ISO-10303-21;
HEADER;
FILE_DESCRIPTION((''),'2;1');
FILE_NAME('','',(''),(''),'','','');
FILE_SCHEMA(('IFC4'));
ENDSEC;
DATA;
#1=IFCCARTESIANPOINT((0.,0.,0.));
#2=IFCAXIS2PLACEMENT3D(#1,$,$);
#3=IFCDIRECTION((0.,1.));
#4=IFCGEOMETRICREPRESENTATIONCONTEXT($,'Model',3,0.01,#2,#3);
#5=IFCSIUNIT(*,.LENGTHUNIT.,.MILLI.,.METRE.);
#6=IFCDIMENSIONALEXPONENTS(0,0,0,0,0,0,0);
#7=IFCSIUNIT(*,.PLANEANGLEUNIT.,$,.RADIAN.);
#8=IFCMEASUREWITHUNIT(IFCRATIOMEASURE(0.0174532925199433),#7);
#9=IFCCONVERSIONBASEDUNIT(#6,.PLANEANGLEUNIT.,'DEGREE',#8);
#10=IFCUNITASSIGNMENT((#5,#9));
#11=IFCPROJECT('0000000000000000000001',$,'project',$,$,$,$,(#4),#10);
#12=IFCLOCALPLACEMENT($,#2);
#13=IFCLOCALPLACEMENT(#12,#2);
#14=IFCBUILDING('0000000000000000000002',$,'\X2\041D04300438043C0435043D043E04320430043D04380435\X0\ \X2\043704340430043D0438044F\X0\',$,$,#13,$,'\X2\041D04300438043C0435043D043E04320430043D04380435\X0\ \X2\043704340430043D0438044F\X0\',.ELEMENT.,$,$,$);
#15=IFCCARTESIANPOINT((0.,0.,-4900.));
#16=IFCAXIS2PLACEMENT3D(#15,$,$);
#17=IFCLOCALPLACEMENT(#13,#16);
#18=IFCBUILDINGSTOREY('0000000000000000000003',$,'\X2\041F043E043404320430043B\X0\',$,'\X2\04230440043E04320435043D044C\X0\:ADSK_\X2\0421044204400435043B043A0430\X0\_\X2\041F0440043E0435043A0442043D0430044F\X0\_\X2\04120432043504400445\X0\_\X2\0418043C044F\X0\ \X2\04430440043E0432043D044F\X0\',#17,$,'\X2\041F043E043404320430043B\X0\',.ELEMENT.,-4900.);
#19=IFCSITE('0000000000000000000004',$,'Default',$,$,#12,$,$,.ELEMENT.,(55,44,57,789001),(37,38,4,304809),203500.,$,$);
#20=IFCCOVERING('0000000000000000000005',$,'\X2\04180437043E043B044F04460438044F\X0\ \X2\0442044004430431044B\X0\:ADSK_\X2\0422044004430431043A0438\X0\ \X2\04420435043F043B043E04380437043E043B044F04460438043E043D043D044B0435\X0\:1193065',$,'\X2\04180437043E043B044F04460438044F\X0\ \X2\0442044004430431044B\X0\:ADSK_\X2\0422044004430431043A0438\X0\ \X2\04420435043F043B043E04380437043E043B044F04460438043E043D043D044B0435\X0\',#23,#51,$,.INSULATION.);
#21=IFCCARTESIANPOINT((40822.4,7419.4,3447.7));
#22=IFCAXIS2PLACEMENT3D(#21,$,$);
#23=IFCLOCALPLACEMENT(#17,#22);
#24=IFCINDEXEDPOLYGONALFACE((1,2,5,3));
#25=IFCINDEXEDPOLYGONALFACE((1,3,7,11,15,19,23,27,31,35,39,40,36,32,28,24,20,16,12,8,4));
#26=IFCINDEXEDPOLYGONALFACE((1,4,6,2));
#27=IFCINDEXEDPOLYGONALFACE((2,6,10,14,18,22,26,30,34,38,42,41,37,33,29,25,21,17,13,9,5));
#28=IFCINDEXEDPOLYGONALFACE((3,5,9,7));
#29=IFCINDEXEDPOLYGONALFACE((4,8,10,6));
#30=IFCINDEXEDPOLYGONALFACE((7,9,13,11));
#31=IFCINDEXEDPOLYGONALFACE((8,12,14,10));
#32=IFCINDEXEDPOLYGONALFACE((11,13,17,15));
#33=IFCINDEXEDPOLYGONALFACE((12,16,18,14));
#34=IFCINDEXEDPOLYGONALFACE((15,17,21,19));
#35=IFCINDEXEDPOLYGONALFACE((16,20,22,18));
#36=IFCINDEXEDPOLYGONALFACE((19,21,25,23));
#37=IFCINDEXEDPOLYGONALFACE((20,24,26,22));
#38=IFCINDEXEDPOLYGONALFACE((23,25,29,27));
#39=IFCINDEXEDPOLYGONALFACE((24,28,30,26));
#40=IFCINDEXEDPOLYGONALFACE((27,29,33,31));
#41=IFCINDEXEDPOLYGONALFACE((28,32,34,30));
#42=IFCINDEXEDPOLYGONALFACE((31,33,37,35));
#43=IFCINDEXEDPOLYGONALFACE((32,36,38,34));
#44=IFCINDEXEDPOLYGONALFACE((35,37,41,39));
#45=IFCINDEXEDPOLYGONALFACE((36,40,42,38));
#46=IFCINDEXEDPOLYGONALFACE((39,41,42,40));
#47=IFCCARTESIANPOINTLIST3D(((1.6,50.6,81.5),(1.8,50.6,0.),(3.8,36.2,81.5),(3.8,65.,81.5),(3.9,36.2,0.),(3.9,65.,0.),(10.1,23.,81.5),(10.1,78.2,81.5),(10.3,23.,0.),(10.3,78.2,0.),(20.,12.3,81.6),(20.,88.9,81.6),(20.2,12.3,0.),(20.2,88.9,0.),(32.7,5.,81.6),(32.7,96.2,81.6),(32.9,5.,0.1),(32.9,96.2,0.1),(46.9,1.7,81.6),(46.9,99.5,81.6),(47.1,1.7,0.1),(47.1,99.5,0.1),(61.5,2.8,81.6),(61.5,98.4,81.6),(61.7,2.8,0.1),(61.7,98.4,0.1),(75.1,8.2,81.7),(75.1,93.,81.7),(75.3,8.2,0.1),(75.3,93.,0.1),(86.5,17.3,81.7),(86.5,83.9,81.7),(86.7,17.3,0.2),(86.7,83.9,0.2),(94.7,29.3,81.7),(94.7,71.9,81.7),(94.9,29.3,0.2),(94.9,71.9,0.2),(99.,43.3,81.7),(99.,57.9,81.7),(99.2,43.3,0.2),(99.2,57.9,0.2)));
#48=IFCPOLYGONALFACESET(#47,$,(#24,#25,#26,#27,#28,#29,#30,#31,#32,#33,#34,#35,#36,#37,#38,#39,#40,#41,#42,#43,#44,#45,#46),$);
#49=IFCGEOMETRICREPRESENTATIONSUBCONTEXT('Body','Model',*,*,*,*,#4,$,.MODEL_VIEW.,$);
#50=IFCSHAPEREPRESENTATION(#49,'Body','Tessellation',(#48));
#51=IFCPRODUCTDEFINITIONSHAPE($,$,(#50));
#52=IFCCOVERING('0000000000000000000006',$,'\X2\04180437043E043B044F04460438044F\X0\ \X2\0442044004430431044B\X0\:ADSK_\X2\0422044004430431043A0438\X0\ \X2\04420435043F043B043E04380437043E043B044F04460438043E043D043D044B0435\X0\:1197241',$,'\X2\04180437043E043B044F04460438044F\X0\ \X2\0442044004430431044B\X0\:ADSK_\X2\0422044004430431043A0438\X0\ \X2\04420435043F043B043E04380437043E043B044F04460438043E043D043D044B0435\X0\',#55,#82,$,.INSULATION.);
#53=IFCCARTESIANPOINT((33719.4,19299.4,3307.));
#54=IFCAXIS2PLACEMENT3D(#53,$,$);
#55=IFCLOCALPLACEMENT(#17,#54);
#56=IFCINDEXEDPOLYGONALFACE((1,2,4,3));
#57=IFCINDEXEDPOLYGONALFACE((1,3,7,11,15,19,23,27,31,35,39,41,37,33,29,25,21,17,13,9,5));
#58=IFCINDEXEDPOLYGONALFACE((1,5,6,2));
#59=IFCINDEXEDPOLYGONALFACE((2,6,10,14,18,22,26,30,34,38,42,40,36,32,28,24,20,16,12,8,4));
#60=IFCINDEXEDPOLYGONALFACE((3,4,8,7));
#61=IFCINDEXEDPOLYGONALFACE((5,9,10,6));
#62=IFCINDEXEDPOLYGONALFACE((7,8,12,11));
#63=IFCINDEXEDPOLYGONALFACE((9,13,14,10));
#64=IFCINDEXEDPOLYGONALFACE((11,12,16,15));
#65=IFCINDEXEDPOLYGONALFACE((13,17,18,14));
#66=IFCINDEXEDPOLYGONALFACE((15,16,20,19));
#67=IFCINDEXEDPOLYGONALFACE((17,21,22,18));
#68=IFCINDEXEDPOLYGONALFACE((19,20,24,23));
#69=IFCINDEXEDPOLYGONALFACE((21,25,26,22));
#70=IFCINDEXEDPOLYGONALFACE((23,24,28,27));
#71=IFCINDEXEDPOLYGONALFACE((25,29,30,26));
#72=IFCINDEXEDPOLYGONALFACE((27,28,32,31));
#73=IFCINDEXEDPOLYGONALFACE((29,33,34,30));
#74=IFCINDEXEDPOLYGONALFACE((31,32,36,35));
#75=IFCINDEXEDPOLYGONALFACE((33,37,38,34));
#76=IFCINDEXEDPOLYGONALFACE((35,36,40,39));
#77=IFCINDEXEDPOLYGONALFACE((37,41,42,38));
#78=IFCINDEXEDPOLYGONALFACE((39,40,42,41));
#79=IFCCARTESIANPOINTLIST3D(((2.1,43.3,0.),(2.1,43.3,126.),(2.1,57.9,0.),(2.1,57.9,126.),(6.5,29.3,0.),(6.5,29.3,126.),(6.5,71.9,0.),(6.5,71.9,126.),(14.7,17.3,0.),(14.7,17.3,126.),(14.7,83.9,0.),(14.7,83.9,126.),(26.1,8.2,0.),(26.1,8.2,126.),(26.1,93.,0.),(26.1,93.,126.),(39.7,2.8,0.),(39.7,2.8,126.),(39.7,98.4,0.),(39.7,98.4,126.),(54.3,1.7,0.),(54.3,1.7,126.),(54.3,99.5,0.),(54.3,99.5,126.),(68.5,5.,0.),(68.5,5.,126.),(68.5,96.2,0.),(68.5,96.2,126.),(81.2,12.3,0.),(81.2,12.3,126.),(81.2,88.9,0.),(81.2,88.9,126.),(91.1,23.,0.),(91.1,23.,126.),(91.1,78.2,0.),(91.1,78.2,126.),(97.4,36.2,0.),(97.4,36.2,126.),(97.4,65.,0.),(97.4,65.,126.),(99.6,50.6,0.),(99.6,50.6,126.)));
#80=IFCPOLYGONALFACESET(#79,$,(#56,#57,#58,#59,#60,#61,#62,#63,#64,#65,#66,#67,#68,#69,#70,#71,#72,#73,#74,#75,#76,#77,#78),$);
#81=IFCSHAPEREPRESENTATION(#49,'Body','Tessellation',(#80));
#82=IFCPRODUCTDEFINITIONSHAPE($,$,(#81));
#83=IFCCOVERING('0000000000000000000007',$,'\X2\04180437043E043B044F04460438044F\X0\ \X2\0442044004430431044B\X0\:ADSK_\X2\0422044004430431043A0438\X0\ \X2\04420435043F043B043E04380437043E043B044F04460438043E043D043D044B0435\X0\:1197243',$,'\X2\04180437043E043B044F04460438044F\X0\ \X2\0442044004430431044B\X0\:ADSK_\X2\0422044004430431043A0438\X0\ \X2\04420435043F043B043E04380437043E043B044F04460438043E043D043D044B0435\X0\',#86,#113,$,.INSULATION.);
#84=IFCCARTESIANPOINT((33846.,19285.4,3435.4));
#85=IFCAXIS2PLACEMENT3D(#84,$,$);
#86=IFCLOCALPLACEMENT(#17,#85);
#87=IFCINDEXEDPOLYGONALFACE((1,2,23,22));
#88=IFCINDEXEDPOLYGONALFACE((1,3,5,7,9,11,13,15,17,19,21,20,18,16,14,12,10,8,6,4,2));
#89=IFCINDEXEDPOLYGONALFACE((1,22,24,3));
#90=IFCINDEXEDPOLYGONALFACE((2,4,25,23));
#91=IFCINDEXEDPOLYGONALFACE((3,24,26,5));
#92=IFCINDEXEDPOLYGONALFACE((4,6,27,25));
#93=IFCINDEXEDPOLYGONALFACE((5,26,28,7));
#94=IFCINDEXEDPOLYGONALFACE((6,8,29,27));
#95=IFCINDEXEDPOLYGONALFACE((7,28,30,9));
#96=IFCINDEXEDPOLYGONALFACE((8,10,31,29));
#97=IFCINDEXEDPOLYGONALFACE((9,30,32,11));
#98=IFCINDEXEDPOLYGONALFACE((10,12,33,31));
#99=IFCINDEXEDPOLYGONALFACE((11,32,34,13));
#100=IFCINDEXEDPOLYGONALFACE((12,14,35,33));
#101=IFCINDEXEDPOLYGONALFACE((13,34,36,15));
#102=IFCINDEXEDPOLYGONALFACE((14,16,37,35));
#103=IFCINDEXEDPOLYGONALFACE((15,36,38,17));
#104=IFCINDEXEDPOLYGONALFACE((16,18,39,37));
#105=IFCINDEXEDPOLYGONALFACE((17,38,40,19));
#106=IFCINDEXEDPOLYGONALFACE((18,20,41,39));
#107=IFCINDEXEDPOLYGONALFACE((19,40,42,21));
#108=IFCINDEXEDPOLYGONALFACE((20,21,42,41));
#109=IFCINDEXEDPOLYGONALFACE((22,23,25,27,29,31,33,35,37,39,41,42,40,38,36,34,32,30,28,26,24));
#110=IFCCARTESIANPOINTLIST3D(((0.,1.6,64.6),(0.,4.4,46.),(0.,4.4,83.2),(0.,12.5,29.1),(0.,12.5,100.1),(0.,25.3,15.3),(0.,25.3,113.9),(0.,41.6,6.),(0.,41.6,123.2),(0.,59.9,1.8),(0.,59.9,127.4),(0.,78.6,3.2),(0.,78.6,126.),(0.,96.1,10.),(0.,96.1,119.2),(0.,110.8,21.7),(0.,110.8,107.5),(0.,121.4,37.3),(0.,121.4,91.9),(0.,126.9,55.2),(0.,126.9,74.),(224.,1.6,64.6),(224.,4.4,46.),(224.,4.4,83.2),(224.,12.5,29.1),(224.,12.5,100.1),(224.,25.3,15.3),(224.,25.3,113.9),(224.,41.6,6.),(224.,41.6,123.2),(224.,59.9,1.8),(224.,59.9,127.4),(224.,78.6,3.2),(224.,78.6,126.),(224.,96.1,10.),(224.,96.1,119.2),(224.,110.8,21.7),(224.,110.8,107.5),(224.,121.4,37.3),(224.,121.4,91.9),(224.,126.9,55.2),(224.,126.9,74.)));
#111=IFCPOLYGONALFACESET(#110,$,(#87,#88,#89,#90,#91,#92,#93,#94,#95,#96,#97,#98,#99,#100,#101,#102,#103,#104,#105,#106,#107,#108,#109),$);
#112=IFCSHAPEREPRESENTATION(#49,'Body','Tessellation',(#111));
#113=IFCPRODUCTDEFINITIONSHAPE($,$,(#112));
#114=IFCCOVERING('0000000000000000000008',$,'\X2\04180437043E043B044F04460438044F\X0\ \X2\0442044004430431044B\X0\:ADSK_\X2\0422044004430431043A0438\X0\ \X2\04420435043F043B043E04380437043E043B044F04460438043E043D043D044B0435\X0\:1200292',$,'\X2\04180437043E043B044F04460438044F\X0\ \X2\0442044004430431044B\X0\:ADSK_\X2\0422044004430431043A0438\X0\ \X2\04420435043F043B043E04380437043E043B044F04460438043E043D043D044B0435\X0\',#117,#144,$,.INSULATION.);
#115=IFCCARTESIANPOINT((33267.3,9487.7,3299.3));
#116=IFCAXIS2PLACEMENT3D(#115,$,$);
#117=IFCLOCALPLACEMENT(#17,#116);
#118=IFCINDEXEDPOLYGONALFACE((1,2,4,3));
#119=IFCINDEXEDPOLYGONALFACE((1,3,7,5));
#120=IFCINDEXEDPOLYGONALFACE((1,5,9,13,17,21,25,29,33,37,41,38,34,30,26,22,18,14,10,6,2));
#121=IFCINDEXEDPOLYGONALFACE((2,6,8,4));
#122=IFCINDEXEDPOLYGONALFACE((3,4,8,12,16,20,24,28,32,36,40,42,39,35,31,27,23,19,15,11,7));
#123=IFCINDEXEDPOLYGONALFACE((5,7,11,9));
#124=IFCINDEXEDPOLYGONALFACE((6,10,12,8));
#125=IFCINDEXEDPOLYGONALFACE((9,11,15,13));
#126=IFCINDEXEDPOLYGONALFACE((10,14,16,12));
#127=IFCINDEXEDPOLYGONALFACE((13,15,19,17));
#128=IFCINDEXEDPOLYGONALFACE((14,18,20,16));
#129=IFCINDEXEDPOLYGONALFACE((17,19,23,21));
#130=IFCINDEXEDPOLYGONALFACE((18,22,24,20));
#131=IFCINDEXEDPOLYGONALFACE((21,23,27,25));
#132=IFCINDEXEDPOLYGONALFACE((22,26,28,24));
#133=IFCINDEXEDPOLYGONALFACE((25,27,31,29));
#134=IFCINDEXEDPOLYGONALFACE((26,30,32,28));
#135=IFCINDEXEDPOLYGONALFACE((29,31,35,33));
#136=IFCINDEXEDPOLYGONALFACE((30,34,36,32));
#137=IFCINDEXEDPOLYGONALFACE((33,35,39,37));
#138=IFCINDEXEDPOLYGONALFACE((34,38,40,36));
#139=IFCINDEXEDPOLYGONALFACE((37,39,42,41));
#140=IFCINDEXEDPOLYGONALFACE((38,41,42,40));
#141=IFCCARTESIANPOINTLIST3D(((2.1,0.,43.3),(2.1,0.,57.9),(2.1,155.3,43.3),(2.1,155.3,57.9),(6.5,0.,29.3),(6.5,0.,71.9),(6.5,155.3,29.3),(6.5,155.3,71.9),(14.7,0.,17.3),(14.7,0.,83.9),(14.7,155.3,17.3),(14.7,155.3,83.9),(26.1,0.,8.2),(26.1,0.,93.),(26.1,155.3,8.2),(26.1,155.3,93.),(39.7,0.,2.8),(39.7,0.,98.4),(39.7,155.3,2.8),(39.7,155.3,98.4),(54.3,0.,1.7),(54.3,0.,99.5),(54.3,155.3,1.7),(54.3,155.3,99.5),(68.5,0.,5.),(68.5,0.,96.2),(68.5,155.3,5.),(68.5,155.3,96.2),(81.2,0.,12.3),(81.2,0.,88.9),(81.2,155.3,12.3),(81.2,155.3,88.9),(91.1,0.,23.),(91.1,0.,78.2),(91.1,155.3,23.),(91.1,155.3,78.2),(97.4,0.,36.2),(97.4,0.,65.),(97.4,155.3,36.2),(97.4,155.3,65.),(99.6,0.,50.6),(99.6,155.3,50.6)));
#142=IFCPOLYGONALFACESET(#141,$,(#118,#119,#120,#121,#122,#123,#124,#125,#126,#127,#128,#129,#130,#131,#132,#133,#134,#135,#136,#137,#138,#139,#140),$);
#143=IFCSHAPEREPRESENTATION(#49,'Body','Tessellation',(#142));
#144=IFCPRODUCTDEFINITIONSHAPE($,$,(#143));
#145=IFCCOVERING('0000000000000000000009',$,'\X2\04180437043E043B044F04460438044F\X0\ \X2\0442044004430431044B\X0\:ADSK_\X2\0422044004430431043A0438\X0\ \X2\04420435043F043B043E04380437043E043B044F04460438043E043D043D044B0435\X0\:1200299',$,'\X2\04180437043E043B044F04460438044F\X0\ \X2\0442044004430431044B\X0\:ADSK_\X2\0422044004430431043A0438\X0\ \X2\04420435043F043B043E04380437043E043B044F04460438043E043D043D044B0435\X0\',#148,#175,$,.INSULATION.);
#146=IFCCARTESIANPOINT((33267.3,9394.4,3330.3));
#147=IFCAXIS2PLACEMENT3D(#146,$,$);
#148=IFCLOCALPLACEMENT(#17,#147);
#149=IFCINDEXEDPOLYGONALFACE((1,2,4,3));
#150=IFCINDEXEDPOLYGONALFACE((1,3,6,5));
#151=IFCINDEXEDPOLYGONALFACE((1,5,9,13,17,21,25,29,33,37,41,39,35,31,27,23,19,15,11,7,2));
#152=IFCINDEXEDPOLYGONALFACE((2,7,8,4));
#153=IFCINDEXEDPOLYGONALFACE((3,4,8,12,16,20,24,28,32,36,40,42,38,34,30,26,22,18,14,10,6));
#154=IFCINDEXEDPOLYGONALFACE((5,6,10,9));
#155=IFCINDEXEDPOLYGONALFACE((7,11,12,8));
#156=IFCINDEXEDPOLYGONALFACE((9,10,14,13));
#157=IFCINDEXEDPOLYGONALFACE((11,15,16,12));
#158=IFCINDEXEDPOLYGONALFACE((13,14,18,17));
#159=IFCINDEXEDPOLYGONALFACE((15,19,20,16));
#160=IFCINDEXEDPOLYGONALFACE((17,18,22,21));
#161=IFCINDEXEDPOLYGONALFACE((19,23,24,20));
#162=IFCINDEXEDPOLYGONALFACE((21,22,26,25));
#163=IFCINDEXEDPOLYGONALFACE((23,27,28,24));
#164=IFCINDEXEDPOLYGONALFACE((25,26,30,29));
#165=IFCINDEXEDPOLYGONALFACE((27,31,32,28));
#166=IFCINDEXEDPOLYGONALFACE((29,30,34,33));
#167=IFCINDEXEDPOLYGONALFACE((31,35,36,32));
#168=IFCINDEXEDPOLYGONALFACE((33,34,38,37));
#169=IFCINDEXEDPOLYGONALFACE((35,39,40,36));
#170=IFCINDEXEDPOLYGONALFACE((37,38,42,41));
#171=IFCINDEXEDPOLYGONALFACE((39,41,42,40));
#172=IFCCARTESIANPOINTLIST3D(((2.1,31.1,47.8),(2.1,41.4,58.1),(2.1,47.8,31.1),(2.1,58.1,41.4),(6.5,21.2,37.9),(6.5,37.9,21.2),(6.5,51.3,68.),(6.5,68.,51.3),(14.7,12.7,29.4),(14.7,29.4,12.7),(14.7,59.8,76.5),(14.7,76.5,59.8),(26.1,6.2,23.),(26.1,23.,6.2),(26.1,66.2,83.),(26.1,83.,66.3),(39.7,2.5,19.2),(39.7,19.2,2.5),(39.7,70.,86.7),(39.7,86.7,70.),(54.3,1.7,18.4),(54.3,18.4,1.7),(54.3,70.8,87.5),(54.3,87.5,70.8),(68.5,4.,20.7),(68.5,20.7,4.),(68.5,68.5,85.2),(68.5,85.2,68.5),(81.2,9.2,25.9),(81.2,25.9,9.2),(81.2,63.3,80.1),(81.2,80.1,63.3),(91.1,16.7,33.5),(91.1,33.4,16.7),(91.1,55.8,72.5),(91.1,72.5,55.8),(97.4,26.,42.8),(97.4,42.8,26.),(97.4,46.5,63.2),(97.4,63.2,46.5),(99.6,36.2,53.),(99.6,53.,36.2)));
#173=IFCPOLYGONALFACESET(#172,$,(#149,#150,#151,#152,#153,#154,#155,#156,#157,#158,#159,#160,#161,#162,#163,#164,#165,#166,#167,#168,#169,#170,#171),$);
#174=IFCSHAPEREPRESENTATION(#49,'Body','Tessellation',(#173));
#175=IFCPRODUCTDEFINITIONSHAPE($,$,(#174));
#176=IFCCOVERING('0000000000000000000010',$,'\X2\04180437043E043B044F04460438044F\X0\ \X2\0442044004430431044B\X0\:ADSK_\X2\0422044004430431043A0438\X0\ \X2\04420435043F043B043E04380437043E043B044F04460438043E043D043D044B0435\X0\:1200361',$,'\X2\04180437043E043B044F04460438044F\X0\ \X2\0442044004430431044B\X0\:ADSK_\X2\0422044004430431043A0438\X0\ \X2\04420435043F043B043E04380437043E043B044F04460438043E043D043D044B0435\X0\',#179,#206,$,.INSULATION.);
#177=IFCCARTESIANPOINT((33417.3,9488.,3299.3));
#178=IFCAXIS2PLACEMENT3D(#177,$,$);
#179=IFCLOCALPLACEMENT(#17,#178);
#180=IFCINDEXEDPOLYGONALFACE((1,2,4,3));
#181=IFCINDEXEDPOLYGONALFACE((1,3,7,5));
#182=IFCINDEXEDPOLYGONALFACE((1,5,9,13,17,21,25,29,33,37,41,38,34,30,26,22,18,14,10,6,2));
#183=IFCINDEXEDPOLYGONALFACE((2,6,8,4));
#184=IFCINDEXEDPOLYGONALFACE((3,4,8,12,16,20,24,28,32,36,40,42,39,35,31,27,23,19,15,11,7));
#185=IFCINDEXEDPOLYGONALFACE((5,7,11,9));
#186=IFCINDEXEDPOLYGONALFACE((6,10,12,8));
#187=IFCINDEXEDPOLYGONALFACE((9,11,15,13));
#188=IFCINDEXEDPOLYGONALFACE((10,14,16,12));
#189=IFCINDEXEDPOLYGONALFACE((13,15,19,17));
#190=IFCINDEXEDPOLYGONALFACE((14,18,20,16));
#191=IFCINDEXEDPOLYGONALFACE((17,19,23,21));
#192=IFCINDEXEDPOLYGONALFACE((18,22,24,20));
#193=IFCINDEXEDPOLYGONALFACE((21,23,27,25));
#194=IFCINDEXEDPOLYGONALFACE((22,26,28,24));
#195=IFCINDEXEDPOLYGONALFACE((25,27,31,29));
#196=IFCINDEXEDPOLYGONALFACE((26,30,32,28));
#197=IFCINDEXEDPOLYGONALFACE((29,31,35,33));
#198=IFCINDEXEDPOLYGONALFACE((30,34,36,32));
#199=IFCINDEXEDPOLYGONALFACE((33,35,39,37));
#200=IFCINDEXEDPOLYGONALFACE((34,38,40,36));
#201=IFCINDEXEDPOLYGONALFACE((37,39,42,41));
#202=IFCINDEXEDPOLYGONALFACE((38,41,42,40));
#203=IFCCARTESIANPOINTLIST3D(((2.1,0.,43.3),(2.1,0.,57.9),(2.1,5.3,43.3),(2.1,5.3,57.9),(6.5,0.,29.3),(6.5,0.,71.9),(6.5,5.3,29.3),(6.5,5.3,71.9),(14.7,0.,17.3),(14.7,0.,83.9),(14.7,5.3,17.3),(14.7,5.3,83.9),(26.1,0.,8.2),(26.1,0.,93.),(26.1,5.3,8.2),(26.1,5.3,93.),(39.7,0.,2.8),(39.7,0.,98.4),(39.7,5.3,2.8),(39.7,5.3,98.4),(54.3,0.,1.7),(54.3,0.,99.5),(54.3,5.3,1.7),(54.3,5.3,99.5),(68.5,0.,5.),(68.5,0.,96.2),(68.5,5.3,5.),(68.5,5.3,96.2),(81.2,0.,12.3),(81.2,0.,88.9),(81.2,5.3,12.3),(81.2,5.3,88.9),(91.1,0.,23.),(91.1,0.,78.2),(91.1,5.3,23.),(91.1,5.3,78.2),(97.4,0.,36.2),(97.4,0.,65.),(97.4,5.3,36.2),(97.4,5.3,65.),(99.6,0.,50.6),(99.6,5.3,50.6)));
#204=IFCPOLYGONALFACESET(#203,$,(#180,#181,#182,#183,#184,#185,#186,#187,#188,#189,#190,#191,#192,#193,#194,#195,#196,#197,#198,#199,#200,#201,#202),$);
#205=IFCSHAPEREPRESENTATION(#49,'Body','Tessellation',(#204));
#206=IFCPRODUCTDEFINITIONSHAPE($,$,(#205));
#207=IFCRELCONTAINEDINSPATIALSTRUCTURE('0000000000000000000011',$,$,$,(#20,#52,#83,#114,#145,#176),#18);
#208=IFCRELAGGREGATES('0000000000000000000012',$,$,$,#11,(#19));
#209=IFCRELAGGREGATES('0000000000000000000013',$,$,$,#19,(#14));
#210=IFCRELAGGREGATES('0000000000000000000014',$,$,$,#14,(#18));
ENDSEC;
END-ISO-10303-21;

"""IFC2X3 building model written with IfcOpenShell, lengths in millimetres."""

from ifc_helpers import new_model, entity, si_unit, converted_unit, direction, frame, origin, origin_2d_with_axis, place, context, subcontext, project, spatial, circle, extrude, element, save


model = new_model("IFC2X3")

# Units and contexts
model_context = context("Model", 3, precision=0.01, world=origin(), true_north=direction((0.0, 1.0)))
body_context = subcontext(model_context, "Body", "Model", "MODEL_VIEW")
ifc_project = project(units=[si_unit("LENGTHUNIT", "METRE", prefix="MILLI"), converted_unit("PLANEANGLEUNIT", "DEGREE", entity("IfcRatioMeasure", 0.0174532925199433), si_unit("PLANEANGLEUNIT", "RADIAN"), dimensions=[0, 0, 0, 0, 0, 0, 0])], contexts=[model_context])

# Site, building, storey
site_placement = place(None, origin())
site = spatial("IfcSite", under=ifc_project, at=site_placement, Name="Default", CompositionType="ELEMENT", RefLatitude=(55, 44, 57, 789001), RefLongitude=(37, 38, 4, 304809), RefElevation=203500.0)
building_placement = place(site_placement, origin())
building = spatial("IfcBuilding", under=site, at=building_placement, Name="Наименование здания", LongName="Наименование здания", CompositionType="ELEMENT")
storey_placement = place(building_placement, frame((0.0, 0.0, -4900.0)))
storey = spatial("IfcBuildingStorey", under=building, at=storey_placement, Name="Подвал", ObjectType="Уровень:ADSK_Стрелка_Проектная_Вверх_Имя уровня", LongName="Подвал", CompositionType="ELEMENT", Elevation=-4900.0)

# Coverings
covering_1_placement = place(storey_placement, frame((40822.4, 7419.4, 3447.7)))
element("IfcCovering", 1, at=covering_1_placement, inside=storey, Name="Изоляция трубы:ADSK_Трубки теплоизоляционные:1193065", ObjectType="Изоляция трубы:ADSK_Трубки теплоизоляционные", PredefinedType="INSULATION", context=body_context, shape_type="SweptSolid", body=[
    extrude(circle(Radius=49.0, at=origin_2d_with_axis()), frame((50.8, 50.6, 0.1), z_axis=(-0.002, 0.0, 0.999998), x_axis=(-0.999998, 0.0, -0.002)), (0.0, 0.0, 1.0), 81.5),
])
covering_2_placement = place(storey_placement, frame((33719.4, 19299.4, 3307.0)))
element("IfcCovering", 2, at=covering_2_placement, inside=storey, Name="Изоляция трубы:ADSK_Трубки теплоизоляционные:1197241", ObjectType="Изоляция трубы:ADSK_Трубки теплоизоляционные", PredefinedType="INSULATION", context=body_context, shape_type="SweptSolid", body=[
    extrude(circle(Radius=49.0, at=origin_2d_with_axis()), frame((50.6, 50.6, 0.0)), (0.0, 0.0, 1.0), 126.0),
])
covering_3_placement = place(storey_placement, frame((33846.0, 19285.4, 3435.4)))
element("IfcCovering", 3, at=covering_3_placement, inside=storey, Name="Изоляция трубы:ADSK_Трубки теплоизоляционные:1197243", ObjectType="Изоляция трубы:ADSK_Трубки теплоизоляционные", PredefinedType="INSULATION", context=body_context, shape_type="SweptSolid", body=[
    extrude(circle(Radius=63.0, at=origin_2d_with_axis()), frame((0.0, 64.6, 64.6), z_axis=(1.0, 0.0, 0.0), x_axis=(0.0, -1.0, 0.0)), (0.0, 0.0, 1.0), 224.0),
])
covering_4_placement = place(storey_placement, frame((33267.3, 9487.7, 3299.3)))
element("IfcCovering", 4, at=covering_4_placement, inside=storey, Name="Изоляция трубы:ADSK_Трубки теплоизоляционные:1200292", ObjectType="Изоляция трубы:ADSK_Трубки теплоизоляционные", PredefinedType="INSULATION", context=body_context, shape_type="SweptSolid", body=[
    extrude(circle(Radius=49.0, at=origin_2d_with_axis()), frame((50.6, 0.0, 50.6), z_axis=(0.0, 1.0, 0.0), x_axis=(1.0, 0.0, 0.0)), (0.0, 0.0, 1.0), 155.3),
])
covering_5_placement = place(storey_placement, frame((33267.3, 9394.4, 3330.3)))
element("IfcCovering", 5, at=covering_5_placement, inside=storey, Name="Изоляция трубы:ADSK_Трубки теплоизоляционные:1200299", ObjectType="Изоляция трубы:ADSK_Трубки теплоизоляционные", PredefinedType="INSULATION", context=body_context, shape_type="SweptSolid", body=[
    extrude(circle(Radius=49.0, at=origin_2d_with_axis()), frame((50.6, 36.2, 53.0), z_axis=(0.0, 0.707107, -0.707107), x_axis=(1.0, 0.0, 0.0)), (0.0, 0.0, 1.0), 23.7),
])
covering_6_placement = place(storey_placement, frame((33417.3, 9488.0, 3299.3)))
element("IfcCovering", 6, at=covering_6_placement, inside=storey, Name="Изоляция трубы:ADSK_Трубки теплоизоляционные:1200361", ObjectType="Изоляция трубы:ADSK_Трубки теплоизоляционные", PredefinedType="INSULATION", context=body_context, shape_type="SweptSolid", body=[
    extrude(circle(Radius=49.0, at=origin_2d_with_axis()), frame((50.6, 0.0, 50.6), z_axis=(0.0, 1.0, 0.0), x_axis=(1.0, 0.0, 0.0)), (0.0, 0.0, 1.0), 5.3),
])

save(model, "model.ifc")
